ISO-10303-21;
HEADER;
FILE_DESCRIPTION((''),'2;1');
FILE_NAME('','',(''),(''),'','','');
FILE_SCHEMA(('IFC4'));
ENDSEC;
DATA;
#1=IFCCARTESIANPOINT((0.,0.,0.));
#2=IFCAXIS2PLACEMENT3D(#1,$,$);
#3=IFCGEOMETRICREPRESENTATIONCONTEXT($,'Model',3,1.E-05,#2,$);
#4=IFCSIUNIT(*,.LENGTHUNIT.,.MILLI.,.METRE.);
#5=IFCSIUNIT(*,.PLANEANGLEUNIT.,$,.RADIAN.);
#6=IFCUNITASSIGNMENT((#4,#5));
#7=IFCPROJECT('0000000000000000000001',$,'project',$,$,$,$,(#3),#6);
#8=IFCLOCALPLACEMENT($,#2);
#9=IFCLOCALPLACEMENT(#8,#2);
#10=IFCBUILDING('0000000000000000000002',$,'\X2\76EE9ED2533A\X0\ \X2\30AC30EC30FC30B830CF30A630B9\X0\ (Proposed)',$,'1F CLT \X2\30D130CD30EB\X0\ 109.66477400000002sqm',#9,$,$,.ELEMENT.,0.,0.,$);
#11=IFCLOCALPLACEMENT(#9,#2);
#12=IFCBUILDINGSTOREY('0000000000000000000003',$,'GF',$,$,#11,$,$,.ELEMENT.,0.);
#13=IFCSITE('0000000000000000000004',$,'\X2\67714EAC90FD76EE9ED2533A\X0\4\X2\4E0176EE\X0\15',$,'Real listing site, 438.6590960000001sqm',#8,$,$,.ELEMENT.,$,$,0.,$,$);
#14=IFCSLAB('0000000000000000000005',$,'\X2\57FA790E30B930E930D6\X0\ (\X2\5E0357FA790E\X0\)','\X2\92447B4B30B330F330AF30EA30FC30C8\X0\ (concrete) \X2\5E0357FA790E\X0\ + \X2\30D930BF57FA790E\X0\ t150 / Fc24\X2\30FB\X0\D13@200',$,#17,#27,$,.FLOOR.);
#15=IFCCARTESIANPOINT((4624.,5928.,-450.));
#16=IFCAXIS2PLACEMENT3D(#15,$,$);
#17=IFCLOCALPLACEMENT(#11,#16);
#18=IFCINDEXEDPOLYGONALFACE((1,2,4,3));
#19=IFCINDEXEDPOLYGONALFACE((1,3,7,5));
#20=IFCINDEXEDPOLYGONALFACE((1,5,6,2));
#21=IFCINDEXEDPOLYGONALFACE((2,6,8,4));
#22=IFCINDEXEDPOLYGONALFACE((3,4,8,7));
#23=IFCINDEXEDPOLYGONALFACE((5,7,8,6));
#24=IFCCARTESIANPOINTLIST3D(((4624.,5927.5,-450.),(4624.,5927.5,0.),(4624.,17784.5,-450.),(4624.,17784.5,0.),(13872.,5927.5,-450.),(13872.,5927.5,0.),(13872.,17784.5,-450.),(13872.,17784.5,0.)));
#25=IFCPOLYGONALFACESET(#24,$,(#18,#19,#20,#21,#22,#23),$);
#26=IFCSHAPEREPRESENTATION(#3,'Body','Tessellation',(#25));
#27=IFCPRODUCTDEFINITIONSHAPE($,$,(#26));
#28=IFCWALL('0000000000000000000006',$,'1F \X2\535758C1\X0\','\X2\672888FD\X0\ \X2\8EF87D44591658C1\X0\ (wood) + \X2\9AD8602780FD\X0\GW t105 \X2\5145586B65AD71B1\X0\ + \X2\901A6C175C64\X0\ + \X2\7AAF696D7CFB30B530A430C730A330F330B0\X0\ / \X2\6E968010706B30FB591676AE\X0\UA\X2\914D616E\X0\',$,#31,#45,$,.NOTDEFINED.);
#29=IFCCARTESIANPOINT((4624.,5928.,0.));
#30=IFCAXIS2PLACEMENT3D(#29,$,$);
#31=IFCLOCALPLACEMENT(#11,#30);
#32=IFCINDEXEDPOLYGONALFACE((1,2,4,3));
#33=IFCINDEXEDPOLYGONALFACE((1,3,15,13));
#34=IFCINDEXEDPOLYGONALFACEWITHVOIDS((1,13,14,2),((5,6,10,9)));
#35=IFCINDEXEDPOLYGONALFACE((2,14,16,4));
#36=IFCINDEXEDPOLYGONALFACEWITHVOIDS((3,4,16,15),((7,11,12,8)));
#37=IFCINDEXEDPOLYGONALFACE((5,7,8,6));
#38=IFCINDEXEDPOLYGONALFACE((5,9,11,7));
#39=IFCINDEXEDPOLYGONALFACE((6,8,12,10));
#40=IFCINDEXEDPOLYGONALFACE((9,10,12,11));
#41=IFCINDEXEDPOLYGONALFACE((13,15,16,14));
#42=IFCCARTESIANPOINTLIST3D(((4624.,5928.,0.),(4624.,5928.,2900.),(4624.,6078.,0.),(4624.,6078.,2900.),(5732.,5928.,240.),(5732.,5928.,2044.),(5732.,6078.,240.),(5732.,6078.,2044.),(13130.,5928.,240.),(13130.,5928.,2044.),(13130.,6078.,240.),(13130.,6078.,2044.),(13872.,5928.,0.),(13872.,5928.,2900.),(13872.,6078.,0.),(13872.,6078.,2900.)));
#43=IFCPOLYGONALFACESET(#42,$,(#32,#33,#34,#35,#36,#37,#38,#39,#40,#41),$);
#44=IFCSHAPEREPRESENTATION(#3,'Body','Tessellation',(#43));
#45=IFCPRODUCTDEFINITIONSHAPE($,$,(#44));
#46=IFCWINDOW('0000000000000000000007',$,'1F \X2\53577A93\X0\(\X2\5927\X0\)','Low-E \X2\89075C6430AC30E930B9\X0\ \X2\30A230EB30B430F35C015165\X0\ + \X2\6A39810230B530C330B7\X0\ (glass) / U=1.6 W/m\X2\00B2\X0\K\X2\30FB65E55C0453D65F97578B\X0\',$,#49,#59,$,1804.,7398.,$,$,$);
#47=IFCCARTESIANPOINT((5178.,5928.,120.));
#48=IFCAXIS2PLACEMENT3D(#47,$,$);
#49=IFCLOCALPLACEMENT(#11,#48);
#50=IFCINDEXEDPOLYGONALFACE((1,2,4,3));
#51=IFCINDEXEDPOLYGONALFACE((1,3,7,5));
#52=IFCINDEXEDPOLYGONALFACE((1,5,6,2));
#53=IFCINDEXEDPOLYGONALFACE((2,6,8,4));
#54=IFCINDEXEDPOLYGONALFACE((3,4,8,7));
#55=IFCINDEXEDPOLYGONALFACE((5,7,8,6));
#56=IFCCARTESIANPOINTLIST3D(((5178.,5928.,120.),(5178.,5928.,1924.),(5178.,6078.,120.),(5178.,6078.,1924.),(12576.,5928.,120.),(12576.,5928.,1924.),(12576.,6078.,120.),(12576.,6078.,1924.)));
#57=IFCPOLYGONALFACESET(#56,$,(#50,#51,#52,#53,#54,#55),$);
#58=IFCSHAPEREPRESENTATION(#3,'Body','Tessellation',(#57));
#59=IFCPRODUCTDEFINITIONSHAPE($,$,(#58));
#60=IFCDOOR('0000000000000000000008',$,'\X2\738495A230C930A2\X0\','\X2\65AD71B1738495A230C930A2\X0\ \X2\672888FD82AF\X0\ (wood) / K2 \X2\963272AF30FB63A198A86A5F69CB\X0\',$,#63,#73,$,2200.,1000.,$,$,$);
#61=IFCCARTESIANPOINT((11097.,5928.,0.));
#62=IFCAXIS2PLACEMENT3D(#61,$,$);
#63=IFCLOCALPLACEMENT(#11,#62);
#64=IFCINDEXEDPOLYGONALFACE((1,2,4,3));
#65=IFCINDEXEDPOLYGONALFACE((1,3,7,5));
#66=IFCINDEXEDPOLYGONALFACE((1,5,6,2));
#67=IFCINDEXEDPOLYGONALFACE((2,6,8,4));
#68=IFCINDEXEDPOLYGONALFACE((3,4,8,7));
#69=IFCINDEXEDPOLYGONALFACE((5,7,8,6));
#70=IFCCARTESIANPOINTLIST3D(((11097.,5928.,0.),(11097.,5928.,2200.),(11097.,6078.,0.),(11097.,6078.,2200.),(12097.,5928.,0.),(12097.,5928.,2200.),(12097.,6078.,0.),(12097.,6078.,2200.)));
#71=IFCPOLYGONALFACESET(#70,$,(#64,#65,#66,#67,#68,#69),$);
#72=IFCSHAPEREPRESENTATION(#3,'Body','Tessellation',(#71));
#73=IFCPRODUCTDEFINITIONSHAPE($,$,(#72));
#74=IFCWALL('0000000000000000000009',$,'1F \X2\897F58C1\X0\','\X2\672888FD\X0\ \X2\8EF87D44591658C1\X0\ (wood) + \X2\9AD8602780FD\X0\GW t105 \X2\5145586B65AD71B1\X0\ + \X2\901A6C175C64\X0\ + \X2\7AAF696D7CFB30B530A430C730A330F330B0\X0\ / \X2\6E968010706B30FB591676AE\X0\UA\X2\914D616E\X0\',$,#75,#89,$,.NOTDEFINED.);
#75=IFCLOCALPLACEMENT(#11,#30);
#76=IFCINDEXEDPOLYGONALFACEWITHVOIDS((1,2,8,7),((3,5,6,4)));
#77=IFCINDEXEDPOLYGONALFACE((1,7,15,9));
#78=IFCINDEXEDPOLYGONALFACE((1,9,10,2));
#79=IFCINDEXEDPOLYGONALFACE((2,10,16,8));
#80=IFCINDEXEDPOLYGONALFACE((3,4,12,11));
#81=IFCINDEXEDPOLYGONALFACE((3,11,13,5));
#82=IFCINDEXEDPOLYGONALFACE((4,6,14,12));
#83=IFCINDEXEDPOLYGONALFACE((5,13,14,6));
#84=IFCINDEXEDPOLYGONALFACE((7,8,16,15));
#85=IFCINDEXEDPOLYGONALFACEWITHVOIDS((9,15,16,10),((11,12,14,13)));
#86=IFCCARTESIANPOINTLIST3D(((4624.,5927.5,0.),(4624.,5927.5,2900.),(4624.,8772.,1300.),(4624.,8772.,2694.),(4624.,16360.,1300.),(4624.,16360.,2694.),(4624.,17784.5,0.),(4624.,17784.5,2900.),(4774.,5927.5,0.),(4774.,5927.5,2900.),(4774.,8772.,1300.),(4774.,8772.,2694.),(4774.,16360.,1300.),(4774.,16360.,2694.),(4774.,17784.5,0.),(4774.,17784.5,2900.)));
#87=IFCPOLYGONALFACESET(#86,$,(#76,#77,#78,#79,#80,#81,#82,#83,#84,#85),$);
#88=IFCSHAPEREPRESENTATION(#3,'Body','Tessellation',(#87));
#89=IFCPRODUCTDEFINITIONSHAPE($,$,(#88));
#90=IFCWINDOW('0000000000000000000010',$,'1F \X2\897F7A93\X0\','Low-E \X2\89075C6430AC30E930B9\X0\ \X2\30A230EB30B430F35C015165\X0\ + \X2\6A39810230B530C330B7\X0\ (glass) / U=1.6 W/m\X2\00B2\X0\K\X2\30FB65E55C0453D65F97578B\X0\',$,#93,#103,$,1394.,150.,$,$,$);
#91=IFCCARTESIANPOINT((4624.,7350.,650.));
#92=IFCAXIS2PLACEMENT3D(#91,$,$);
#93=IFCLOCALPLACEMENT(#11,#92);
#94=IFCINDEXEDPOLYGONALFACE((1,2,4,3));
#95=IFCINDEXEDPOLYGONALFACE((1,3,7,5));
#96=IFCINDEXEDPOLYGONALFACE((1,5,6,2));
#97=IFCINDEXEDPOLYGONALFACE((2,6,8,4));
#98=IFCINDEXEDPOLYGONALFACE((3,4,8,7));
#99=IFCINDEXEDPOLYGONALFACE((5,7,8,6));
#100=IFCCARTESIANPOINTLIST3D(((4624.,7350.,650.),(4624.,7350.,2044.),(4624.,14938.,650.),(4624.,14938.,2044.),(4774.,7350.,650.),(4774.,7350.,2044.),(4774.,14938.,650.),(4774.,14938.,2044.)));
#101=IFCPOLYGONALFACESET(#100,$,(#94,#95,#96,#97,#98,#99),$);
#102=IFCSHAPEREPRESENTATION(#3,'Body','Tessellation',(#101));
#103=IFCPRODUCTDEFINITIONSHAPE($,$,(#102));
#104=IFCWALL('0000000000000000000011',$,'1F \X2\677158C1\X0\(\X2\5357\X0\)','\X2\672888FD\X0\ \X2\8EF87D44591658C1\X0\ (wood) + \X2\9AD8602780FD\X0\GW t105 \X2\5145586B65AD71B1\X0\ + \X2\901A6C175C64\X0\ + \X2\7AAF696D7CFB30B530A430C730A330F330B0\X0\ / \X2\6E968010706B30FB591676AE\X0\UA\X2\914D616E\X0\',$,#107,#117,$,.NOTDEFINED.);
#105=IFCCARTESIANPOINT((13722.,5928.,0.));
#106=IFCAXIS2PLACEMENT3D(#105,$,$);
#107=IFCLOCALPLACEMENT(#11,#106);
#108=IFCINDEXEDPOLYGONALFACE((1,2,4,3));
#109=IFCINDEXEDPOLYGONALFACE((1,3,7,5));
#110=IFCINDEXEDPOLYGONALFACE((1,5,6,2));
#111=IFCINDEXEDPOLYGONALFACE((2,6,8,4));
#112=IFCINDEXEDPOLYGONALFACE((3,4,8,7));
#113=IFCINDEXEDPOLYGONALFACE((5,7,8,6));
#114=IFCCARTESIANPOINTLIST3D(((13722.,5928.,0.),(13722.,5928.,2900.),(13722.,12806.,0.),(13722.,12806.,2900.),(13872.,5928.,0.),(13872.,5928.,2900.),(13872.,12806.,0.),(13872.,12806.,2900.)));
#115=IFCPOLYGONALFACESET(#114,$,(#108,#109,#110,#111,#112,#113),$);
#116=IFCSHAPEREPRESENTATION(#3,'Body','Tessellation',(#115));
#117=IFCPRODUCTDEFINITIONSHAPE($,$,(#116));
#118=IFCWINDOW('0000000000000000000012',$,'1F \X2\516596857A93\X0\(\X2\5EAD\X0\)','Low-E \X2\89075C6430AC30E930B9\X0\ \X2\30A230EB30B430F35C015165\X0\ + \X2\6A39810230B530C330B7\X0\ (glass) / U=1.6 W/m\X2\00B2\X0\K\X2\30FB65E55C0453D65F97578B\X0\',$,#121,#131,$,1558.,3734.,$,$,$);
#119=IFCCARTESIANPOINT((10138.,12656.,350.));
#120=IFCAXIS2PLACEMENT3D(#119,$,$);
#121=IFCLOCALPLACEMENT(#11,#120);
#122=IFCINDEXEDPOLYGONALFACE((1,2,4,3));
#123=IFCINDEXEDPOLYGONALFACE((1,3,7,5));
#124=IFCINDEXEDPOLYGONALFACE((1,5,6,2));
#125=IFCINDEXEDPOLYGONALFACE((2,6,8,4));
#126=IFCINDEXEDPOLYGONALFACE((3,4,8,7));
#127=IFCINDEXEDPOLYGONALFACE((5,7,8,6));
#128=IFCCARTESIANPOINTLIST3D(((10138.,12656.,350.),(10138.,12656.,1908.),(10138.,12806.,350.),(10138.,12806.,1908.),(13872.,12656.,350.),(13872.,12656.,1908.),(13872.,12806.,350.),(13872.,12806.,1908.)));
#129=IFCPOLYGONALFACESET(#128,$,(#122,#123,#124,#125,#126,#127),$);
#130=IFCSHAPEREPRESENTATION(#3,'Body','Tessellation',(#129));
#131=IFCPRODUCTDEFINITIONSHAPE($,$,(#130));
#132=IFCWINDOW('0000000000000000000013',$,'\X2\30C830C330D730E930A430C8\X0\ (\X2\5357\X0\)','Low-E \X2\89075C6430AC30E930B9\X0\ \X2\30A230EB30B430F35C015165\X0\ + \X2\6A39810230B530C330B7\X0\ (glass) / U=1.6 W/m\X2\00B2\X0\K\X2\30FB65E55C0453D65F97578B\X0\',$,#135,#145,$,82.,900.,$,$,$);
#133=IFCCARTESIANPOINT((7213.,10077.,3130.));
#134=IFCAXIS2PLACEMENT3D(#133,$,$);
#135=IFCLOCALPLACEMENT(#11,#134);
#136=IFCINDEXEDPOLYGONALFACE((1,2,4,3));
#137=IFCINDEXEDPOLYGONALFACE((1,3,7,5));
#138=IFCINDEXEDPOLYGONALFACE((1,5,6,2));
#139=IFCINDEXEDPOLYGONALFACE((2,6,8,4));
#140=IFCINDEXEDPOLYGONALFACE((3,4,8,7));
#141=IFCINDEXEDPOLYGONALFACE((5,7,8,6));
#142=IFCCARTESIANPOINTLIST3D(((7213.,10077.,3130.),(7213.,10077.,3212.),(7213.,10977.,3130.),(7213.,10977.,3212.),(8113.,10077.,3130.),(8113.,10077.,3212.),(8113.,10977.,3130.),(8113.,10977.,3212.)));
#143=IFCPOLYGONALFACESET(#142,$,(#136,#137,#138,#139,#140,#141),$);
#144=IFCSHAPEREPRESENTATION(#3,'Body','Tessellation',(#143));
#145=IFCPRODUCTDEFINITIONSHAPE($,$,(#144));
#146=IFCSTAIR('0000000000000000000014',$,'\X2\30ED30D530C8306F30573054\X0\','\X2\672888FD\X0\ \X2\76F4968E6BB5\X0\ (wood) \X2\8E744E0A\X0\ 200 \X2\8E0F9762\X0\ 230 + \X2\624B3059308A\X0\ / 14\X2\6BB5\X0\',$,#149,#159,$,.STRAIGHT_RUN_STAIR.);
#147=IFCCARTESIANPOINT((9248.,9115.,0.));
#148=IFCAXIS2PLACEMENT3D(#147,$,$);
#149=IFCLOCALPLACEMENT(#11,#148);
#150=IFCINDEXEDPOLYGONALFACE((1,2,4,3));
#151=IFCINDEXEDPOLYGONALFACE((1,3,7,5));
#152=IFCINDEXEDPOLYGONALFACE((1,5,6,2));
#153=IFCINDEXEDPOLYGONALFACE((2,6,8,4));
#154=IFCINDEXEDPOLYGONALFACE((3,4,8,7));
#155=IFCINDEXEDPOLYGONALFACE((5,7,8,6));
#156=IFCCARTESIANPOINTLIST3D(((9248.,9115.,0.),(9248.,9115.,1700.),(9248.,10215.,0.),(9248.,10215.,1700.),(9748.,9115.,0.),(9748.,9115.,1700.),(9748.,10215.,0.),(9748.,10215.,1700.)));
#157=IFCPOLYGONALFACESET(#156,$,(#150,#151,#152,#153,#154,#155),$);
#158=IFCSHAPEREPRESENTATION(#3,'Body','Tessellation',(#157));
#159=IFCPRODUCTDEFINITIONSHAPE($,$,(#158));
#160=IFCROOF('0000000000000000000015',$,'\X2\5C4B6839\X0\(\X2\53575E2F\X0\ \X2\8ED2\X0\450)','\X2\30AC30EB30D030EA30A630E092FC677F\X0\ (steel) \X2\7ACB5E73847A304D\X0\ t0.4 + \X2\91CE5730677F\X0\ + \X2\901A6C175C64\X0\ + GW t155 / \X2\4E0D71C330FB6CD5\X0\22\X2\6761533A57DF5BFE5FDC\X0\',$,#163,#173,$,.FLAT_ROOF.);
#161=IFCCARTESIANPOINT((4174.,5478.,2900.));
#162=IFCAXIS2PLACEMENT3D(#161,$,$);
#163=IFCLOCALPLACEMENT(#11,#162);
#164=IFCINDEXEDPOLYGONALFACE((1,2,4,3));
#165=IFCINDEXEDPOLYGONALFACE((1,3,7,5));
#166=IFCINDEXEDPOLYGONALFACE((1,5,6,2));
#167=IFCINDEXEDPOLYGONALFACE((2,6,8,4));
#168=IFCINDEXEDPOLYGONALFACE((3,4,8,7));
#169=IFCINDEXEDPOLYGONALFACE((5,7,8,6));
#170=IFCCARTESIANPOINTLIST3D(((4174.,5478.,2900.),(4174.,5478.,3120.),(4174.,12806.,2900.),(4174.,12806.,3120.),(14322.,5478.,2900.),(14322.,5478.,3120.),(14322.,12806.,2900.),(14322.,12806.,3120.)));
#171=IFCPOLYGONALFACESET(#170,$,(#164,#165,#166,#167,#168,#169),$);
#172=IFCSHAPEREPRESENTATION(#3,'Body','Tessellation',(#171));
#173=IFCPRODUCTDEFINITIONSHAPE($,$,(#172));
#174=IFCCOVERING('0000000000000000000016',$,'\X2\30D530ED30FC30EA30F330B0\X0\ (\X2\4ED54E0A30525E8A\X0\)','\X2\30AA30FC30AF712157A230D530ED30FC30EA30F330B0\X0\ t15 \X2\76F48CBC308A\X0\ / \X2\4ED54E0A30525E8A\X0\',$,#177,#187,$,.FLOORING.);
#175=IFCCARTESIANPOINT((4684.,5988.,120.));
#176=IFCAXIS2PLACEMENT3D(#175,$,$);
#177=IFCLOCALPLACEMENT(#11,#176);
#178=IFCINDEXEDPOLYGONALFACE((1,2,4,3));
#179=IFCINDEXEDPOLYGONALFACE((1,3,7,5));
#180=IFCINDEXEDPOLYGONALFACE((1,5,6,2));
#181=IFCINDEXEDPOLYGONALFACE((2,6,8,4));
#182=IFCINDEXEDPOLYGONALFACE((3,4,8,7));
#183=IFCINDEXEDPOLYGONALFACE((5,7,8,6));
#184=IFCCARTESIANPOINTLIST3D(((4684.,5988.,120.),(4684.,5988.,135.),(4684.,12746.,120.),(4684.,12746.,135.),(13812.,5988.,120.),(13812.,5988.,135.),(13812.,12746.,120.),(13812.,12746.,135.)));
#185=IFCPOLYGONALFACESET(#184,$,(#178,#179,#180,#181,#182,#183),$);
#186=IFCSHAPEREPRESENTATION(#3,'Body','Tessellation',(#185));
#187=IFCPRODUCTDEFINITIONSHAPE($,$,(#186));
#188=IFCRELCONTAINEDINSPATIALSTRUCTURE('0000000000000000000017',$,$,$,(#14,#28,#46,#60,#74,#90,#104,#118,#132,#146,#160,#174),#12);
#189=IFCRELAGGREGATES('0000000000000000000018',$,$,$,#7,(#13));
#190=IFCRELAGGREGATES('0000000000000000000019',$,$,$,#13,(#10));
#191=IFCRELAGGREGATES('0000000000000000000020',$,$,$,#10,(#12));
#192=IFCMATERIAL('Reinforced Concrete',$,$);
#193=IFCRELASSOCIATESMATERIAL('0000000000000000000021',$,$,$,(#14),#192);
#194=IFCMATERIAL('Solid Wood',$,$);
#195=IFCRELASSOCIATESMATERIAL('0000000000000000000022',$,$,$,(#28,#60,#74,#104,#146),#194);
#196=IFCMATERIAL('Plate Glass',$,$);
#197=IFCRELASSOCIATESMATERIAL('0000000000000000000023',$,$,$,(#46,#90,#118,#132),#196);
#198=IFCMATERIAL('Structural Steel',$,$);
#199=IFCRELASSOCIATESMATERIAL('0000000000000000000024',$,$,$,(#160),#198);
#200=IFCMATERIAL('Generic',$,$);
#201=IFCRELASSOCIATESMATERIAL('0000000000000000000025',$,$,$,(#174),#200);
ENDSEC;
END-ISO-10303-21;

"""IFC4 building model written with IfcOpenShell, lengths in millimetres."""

from ifc_helpers import new_model, si_unit, frame, frame_2d, origin, place, context, project, spatial, rectangle, extrude, material, element, fill, save


model = new_model("IFC4")

# Units and contexts
model_context = context("Model", 3, precision=1e-05, world=origin())
ifc_project = project(units=[si_unit("LENGTHUNIT", "METRE", prefix="MILLI"), si_unit("PLANEANGLEUNIT", "RADIAN")], contexts=[model_context])

# Site, building, storey
site_placement = place(None, origin())
site = spatial("IfcSite", under=ifc_project, at=site_placement, Name="東京都目黒区4丁目15", ObjectType="Real listing site, 438.6590960000001sqm", CompositionType="ELEMENT", RefElevation=0.0)
building_placement = place(site_placement, origin())
building = spatial("IfcBuilding", under=site, at=building_placement, Name="目黒区 ガレージハウス (Proposed)", ObjectType="1F CLT パネル 109.66477400000002sqm", CompositionType="ELEMENT", ElevationOfRefHeight=0.0, ElevationOfTerrain=0.0)
storey_placement = place(building_placement, origin())
storey = spatial("IfcBuildingStorey", under=building, at=storey_placement, Name="GF", CompositionType="ELEMENT", Elevation=0.0)

# Slab
ifc_material_1 = material(Name="Reinforced Concrete")
slab_1_placement = place(storey_placement, frame((4624.0, 5928.0, -450.0)))
element("IfcSlab", 1, at=slab_1_placement, inside=storey, material=ifc_material_1, Name="基礎スラブ (布基礎)", Description="鉄筋コンクリート (concrete) 布基礎 + ベタ基礎 t150 / Fc24・D13@200", PredefinedType="FLOOR", context=model_context, shape_type="SweptSolid", body=[
    extrude(rectangle(XDim=9248.0, YDim=11857.0, at=frame_2d((4624.0, 5928.0))), frame((4624.0, 5928.0, -450.0)), (0.0, 0.0, 1.0), 450.0),
])
ifc_material_2 = material(Name="Solid Wood")

# Wall, openings, window, door
wall_1_placement = place(storey_placement, frame((4624.0, 5928.0, 0.0)))
wall_1 = element("IfcWall", 2, at=wall_1_placement, inside=storey, material=ifc_material_2, Name="1F 南壁", Description="木製 軸組外壁 (wood) + 高性能GW t105 充填断熱 + 通気層 + 窯業系サイディング / 準耐火・外皮UA配慮", PredefinedType="NOTDEFINED", context=model_context, shape_type="SweptSolid", body=[
    extrude(rectangle(XDim=9248.0, YDim=150.0, at=frame_2d((4624.0, 75.0))), frame((4624.0, 5928.0, 0.0)), (0.0, 0.0, 1.0), 2900.0),
])
opening_1_placement = place(storey_placement, frame((5178.0, 5928.0, 120.0)))
opening_1 = element("IfcOpeningElement", 3, at=opening_1_placement, cuts=wall_1, PredefinedType="NOTDEFINED", context=model_context, shape_type="SweptSolid", body=[
    extrude(rectangle(XDim=7398.0, YDim=150.0, at=frame_2d((3699.0, 75.0))), frame((5178.0, 5928.0, 120.0)), (0.0, 0.0, 1.0), 1804.0),
])
opening_2_placement = place(storey_placement, frame((11097.0, 5928.0, 0.0)))
opening_2 = element("IfcOpeningElement", 4, at=opening_2_placement, cuts=wall_1, PredefinedType="NOTDEFINED", context=model_context, shape_type="SweptSolid", body=[
    extrude(rectangle(XDim=1000.0, YDim=150.0, at=frame_2d((500.0, 75.0))), frame((11097.0, 5928.0, 0.0)), (0.0, 0.0, 1.0), 2200.0),
])
ifc_material_3 = material(Name="Plate Glass")
window_1_placement = place(storey_placement, frame((5178.0, 5928.0, 120.0)))
window_1 = element("IfcWindow", 5, at=window_1_placement, inside=storey, material=ifc_material_3, Name="1F 南窓(大)", Description="Low-E 複層ガラス アルゴン封入 + 樹脂サッシ (glass) / U=1.6 W/m²K・日射取得型", OverallHeight=1804.0, OverallWidth=7398.0, context=model_context, shape_type="SweptSolid", body=[
    extrude(rectangle(XDim=7398.0, YDim=150.0, at=frame_2d((3699.0, 75.0))), frame((5178.0, 5928.0, 120.0)), (0.0, 0.0, 1.0), 1804.0),
])
fill(opening_1, window_1)
door_1_placement = place(storey_placement, frame((11097.0, 5928.0, 0.0)))
door_1 = element("IfcDoor", 6, at=door_1_placement, inside=storey, material=ifc_material_2, Name="玄関ドア", Description="断熱玄関ドア 木製芯 (wood) / K2 防犯・採風機構", OverallHeight=2200.0, OverallWidth=1000.0, context=model_context, shape_type="SweptSolid", body=[
    extrude(rectangle(XDim=1000.0, YDim=150.0, at=frame_2d((500.0, 75.0))), frame((11097.0, 5928.0, 0.0)), (0.0, 0.0, 1.0), 2200.0),
])
fill(opening_2, door_1)

# Walls, openings, windows
wall_2_placement = place(storey_placement, frame((4624.0, 5928.0, 0.0)))
wall_2 = element("IfcWall", 7, at=wall_2_placement, inside=storey, material=ifc_material_2, Name="1F 西壁", Description="木製 軸組外壁 (wood) + 高性能GW t105 充填断熱 + 通気層 + 窯業系サイディング / 準耐火・外皮UA配慮", PredefinedType="NOTDEFINED", context=model_context, shape_type="SweptSolid", body=[
    extrude(rectangle(XDim=150.0, YDim=11857.0, at=frame_2d((75.0, 5928.0))), frame((4624.0, 5928.0, 0.0)), (0.0, 0.0, 1.0), 2900.0),
])
opening_3_placement = place(storey_placement, frame((4624.0, 7350.0, 650.0)))
opening_3 = element("IfcOpeningElement", 8, at=opening_3_placement, cuts=wall_2, PredefinedType="NOTDEFINED", context=model_context, shape_type="SweptSolid", body=[
    extrude(rectangle(XDim=150.0, YDim=7588.0, at=frame_2d((75.0, 3794.0))), frame((4624.0, 7350.0, 650.0)), (0.0, 0.0, 1.0), 1394.0),
])
window_2_placement = place(storey_placement, frame((4624.0, 7350.0, 650.0)))
window_2 = element("IfcWindow", 9, at=window_2_placement, inside=storey, material=ifc_material_3, Name="1F 西窓", Description="Low-E 複層ガラス アルゴン封入 + 樹脂サッシ (glass) / U=1.6 W/m²K・日射取得型", OverallHeight=1394.0, OverallWidth=150.0, context=model_context, shape_type="SweptSolid", body=[
    extrude(rectangle(XDim=150.0, YDim=7588.0, at=frame_2d((75.0, 3794.0))), frame((4624.0, 7350.0, 650.0)), (0.0, 0.0, 1.0), 1394.0),
])
fill(opening_3, window_2)
wall_3_placement = place(storey_placement, frame((13722.0, 5928.0, 0.0)))
wall_3 = element("IfcWall", 10, at=wall_3_placement, inside=storey, material=ifc_material_2, Name="1F 東壁(南)", Description="木製 軸組外壁 (wood) + 高性能GW t105 充填断熱 + 通気層 + 窯業系サイディング / 準耐火・外皮UA配慮", PredefinedType="NOTDEFINED", context=model_context, shape_type="SweptSolid", body=[
    extrude(rectangle(XDim=150.0, YDim=6878.0, at=frame_2d((75.0, 3439.0))), frame((13722.0, 5928.0, 0.0)), (0.0, 0.0, 1.0), 2900.0),
])
opening_4_placement = place(storey_placement, frame((10138.0, 12656.0, 350.0)))
opening_4 = element("IfcOpeningElement", 11, at=opening_4_placement, cuts=wall_3, PredefinedType="NOTDEFINED", context=model_context, shape_type="SweptSolid", body=[
    extrude(rectangle(XDim=3734.0, YDim=150.0, at=frame_2d((1867.0, 75.0))), frame((10138.0, 12656.0, 350.0)), (0.0, 0.0, 1.0), 1558.0),
])
window_3_placement = place(storey_placement, frame((10138.0, 12656.0, 350.0)))
window_3 = element("IfcWindow", 12, at=window_3_placement, inside=storey, material=ifc_material_3, Name="1F 入隅窓(庭)", Description="Low-E 複層ガラス アルゴン封入 + 樹脂サッシ (glass) / U=1.6 W/m²K・日射取得型", OverallHeight=1558.0, OverallWidth=3734.0, context=model_context, shape_type="SweptSolid", body=[
    extrude(rectangle(XDim=3734.0, YDim=150.0, at=frame_2d((1867.0, 75.0))), frame((10138.0, 12656.0, 350.0)), (0.0, 0.0, 1.0), 1558.0),
])
fill(opening_4, window_3)

# Window
window_4_placement = place(storey_placement, frame((7213.0, 10077.0, 3130.0)))
element("IfcWindow", 13, at=window_4_placement, inside=storey, material=ifc_material_3, Name="トップライト (南)", Description="Low-E 複層ガラス アルゴン封入 + 樹脂サッシ (glass) / U=1.6 W/m²K・日射取得型", OverallHeight=82.0, OverallWidth=900.0, context=model_context, shape_type="SweptSolid", body=[
    extrude(rectangle(XDim=900.0, YDim=900.0, at=frame_2d((450.0, 450.0))), frame((7213.0, 10077.0, 3130.0)), (0.0, 0.0, 1.0), 82.0),
])

# Stair
stair_placement = place(storey_placement, frame((9248.0, 9115.0, 0.0)))
element("IfcStair", 14, at=stair_placement, inside=storey, material=ifc_material_2, Name="ロフトはしご", Description="木製 直階段 (wood) 蹴上 200 踏面 230 + 手すり / 14段", PredefinedType="STRAIGHT_RUN_STAIR", context=model_context, shape_type="SweptSolid", body=[
    extrude(rectangle(XDim=500.0, YDim=1100.0, at=frame_2d((250.0, 550.0))), frame((9248.0, 9115.0, 0.0)), (0.0, 0.0, 1.0), 1700.0),
])

# Roof
ifc_material_4 = material(Name="Structural Steel")
roof_placement = place(storey_placement, frame((4174.0, 5478.0, 2900.0)))
element("IfcRoof", 15, at=roof_placement, inside=storey, material=ifc_material_4, Name="屋根(南帯 軒450)", Description="ガルバリウム鋼板 (steel) 立平葺き t0.4 + 野地板 + 通気層 + GW t155 / 不燃・法22条区域対応", PredefinedType="FLAT_ROOF", context=model_context, shape_type="SweptSolid", body=[
    extrude(rectangle(XDim=10148.0, YDim=7328.0, at=frame_2d((5074.0, 3664.0))), frame((4174.0, 5478.0, 2900.0)), (0.0, 0.0, 1.0), 220.0),
])

# Covering
ifc_material_5 = material(Name="Generic")
covering_placement = place(storey_placement, frame((4684.0, 5988.0, 120.0)))
element("IfcCovering", 16, at=covering_placement, inside=storey, material=ifc_material_5, Name="フローリング (仕上げ床)", Description="オーク無垢フローリング t15 直貼り / 仕上げ床", PredefinedType="FLOORING", context=model_context, shape_type="SweptSolid", body=[
    extrude(rectangle(XDim=9128.0, YDim=6758.0, at=frame_2d((4564.0, 3379.0))), frame((4684.0, 5988.0, 120.0)), (0.0, 0.0, 1.0), 15.0),
])

save(model, "model.ifc")
